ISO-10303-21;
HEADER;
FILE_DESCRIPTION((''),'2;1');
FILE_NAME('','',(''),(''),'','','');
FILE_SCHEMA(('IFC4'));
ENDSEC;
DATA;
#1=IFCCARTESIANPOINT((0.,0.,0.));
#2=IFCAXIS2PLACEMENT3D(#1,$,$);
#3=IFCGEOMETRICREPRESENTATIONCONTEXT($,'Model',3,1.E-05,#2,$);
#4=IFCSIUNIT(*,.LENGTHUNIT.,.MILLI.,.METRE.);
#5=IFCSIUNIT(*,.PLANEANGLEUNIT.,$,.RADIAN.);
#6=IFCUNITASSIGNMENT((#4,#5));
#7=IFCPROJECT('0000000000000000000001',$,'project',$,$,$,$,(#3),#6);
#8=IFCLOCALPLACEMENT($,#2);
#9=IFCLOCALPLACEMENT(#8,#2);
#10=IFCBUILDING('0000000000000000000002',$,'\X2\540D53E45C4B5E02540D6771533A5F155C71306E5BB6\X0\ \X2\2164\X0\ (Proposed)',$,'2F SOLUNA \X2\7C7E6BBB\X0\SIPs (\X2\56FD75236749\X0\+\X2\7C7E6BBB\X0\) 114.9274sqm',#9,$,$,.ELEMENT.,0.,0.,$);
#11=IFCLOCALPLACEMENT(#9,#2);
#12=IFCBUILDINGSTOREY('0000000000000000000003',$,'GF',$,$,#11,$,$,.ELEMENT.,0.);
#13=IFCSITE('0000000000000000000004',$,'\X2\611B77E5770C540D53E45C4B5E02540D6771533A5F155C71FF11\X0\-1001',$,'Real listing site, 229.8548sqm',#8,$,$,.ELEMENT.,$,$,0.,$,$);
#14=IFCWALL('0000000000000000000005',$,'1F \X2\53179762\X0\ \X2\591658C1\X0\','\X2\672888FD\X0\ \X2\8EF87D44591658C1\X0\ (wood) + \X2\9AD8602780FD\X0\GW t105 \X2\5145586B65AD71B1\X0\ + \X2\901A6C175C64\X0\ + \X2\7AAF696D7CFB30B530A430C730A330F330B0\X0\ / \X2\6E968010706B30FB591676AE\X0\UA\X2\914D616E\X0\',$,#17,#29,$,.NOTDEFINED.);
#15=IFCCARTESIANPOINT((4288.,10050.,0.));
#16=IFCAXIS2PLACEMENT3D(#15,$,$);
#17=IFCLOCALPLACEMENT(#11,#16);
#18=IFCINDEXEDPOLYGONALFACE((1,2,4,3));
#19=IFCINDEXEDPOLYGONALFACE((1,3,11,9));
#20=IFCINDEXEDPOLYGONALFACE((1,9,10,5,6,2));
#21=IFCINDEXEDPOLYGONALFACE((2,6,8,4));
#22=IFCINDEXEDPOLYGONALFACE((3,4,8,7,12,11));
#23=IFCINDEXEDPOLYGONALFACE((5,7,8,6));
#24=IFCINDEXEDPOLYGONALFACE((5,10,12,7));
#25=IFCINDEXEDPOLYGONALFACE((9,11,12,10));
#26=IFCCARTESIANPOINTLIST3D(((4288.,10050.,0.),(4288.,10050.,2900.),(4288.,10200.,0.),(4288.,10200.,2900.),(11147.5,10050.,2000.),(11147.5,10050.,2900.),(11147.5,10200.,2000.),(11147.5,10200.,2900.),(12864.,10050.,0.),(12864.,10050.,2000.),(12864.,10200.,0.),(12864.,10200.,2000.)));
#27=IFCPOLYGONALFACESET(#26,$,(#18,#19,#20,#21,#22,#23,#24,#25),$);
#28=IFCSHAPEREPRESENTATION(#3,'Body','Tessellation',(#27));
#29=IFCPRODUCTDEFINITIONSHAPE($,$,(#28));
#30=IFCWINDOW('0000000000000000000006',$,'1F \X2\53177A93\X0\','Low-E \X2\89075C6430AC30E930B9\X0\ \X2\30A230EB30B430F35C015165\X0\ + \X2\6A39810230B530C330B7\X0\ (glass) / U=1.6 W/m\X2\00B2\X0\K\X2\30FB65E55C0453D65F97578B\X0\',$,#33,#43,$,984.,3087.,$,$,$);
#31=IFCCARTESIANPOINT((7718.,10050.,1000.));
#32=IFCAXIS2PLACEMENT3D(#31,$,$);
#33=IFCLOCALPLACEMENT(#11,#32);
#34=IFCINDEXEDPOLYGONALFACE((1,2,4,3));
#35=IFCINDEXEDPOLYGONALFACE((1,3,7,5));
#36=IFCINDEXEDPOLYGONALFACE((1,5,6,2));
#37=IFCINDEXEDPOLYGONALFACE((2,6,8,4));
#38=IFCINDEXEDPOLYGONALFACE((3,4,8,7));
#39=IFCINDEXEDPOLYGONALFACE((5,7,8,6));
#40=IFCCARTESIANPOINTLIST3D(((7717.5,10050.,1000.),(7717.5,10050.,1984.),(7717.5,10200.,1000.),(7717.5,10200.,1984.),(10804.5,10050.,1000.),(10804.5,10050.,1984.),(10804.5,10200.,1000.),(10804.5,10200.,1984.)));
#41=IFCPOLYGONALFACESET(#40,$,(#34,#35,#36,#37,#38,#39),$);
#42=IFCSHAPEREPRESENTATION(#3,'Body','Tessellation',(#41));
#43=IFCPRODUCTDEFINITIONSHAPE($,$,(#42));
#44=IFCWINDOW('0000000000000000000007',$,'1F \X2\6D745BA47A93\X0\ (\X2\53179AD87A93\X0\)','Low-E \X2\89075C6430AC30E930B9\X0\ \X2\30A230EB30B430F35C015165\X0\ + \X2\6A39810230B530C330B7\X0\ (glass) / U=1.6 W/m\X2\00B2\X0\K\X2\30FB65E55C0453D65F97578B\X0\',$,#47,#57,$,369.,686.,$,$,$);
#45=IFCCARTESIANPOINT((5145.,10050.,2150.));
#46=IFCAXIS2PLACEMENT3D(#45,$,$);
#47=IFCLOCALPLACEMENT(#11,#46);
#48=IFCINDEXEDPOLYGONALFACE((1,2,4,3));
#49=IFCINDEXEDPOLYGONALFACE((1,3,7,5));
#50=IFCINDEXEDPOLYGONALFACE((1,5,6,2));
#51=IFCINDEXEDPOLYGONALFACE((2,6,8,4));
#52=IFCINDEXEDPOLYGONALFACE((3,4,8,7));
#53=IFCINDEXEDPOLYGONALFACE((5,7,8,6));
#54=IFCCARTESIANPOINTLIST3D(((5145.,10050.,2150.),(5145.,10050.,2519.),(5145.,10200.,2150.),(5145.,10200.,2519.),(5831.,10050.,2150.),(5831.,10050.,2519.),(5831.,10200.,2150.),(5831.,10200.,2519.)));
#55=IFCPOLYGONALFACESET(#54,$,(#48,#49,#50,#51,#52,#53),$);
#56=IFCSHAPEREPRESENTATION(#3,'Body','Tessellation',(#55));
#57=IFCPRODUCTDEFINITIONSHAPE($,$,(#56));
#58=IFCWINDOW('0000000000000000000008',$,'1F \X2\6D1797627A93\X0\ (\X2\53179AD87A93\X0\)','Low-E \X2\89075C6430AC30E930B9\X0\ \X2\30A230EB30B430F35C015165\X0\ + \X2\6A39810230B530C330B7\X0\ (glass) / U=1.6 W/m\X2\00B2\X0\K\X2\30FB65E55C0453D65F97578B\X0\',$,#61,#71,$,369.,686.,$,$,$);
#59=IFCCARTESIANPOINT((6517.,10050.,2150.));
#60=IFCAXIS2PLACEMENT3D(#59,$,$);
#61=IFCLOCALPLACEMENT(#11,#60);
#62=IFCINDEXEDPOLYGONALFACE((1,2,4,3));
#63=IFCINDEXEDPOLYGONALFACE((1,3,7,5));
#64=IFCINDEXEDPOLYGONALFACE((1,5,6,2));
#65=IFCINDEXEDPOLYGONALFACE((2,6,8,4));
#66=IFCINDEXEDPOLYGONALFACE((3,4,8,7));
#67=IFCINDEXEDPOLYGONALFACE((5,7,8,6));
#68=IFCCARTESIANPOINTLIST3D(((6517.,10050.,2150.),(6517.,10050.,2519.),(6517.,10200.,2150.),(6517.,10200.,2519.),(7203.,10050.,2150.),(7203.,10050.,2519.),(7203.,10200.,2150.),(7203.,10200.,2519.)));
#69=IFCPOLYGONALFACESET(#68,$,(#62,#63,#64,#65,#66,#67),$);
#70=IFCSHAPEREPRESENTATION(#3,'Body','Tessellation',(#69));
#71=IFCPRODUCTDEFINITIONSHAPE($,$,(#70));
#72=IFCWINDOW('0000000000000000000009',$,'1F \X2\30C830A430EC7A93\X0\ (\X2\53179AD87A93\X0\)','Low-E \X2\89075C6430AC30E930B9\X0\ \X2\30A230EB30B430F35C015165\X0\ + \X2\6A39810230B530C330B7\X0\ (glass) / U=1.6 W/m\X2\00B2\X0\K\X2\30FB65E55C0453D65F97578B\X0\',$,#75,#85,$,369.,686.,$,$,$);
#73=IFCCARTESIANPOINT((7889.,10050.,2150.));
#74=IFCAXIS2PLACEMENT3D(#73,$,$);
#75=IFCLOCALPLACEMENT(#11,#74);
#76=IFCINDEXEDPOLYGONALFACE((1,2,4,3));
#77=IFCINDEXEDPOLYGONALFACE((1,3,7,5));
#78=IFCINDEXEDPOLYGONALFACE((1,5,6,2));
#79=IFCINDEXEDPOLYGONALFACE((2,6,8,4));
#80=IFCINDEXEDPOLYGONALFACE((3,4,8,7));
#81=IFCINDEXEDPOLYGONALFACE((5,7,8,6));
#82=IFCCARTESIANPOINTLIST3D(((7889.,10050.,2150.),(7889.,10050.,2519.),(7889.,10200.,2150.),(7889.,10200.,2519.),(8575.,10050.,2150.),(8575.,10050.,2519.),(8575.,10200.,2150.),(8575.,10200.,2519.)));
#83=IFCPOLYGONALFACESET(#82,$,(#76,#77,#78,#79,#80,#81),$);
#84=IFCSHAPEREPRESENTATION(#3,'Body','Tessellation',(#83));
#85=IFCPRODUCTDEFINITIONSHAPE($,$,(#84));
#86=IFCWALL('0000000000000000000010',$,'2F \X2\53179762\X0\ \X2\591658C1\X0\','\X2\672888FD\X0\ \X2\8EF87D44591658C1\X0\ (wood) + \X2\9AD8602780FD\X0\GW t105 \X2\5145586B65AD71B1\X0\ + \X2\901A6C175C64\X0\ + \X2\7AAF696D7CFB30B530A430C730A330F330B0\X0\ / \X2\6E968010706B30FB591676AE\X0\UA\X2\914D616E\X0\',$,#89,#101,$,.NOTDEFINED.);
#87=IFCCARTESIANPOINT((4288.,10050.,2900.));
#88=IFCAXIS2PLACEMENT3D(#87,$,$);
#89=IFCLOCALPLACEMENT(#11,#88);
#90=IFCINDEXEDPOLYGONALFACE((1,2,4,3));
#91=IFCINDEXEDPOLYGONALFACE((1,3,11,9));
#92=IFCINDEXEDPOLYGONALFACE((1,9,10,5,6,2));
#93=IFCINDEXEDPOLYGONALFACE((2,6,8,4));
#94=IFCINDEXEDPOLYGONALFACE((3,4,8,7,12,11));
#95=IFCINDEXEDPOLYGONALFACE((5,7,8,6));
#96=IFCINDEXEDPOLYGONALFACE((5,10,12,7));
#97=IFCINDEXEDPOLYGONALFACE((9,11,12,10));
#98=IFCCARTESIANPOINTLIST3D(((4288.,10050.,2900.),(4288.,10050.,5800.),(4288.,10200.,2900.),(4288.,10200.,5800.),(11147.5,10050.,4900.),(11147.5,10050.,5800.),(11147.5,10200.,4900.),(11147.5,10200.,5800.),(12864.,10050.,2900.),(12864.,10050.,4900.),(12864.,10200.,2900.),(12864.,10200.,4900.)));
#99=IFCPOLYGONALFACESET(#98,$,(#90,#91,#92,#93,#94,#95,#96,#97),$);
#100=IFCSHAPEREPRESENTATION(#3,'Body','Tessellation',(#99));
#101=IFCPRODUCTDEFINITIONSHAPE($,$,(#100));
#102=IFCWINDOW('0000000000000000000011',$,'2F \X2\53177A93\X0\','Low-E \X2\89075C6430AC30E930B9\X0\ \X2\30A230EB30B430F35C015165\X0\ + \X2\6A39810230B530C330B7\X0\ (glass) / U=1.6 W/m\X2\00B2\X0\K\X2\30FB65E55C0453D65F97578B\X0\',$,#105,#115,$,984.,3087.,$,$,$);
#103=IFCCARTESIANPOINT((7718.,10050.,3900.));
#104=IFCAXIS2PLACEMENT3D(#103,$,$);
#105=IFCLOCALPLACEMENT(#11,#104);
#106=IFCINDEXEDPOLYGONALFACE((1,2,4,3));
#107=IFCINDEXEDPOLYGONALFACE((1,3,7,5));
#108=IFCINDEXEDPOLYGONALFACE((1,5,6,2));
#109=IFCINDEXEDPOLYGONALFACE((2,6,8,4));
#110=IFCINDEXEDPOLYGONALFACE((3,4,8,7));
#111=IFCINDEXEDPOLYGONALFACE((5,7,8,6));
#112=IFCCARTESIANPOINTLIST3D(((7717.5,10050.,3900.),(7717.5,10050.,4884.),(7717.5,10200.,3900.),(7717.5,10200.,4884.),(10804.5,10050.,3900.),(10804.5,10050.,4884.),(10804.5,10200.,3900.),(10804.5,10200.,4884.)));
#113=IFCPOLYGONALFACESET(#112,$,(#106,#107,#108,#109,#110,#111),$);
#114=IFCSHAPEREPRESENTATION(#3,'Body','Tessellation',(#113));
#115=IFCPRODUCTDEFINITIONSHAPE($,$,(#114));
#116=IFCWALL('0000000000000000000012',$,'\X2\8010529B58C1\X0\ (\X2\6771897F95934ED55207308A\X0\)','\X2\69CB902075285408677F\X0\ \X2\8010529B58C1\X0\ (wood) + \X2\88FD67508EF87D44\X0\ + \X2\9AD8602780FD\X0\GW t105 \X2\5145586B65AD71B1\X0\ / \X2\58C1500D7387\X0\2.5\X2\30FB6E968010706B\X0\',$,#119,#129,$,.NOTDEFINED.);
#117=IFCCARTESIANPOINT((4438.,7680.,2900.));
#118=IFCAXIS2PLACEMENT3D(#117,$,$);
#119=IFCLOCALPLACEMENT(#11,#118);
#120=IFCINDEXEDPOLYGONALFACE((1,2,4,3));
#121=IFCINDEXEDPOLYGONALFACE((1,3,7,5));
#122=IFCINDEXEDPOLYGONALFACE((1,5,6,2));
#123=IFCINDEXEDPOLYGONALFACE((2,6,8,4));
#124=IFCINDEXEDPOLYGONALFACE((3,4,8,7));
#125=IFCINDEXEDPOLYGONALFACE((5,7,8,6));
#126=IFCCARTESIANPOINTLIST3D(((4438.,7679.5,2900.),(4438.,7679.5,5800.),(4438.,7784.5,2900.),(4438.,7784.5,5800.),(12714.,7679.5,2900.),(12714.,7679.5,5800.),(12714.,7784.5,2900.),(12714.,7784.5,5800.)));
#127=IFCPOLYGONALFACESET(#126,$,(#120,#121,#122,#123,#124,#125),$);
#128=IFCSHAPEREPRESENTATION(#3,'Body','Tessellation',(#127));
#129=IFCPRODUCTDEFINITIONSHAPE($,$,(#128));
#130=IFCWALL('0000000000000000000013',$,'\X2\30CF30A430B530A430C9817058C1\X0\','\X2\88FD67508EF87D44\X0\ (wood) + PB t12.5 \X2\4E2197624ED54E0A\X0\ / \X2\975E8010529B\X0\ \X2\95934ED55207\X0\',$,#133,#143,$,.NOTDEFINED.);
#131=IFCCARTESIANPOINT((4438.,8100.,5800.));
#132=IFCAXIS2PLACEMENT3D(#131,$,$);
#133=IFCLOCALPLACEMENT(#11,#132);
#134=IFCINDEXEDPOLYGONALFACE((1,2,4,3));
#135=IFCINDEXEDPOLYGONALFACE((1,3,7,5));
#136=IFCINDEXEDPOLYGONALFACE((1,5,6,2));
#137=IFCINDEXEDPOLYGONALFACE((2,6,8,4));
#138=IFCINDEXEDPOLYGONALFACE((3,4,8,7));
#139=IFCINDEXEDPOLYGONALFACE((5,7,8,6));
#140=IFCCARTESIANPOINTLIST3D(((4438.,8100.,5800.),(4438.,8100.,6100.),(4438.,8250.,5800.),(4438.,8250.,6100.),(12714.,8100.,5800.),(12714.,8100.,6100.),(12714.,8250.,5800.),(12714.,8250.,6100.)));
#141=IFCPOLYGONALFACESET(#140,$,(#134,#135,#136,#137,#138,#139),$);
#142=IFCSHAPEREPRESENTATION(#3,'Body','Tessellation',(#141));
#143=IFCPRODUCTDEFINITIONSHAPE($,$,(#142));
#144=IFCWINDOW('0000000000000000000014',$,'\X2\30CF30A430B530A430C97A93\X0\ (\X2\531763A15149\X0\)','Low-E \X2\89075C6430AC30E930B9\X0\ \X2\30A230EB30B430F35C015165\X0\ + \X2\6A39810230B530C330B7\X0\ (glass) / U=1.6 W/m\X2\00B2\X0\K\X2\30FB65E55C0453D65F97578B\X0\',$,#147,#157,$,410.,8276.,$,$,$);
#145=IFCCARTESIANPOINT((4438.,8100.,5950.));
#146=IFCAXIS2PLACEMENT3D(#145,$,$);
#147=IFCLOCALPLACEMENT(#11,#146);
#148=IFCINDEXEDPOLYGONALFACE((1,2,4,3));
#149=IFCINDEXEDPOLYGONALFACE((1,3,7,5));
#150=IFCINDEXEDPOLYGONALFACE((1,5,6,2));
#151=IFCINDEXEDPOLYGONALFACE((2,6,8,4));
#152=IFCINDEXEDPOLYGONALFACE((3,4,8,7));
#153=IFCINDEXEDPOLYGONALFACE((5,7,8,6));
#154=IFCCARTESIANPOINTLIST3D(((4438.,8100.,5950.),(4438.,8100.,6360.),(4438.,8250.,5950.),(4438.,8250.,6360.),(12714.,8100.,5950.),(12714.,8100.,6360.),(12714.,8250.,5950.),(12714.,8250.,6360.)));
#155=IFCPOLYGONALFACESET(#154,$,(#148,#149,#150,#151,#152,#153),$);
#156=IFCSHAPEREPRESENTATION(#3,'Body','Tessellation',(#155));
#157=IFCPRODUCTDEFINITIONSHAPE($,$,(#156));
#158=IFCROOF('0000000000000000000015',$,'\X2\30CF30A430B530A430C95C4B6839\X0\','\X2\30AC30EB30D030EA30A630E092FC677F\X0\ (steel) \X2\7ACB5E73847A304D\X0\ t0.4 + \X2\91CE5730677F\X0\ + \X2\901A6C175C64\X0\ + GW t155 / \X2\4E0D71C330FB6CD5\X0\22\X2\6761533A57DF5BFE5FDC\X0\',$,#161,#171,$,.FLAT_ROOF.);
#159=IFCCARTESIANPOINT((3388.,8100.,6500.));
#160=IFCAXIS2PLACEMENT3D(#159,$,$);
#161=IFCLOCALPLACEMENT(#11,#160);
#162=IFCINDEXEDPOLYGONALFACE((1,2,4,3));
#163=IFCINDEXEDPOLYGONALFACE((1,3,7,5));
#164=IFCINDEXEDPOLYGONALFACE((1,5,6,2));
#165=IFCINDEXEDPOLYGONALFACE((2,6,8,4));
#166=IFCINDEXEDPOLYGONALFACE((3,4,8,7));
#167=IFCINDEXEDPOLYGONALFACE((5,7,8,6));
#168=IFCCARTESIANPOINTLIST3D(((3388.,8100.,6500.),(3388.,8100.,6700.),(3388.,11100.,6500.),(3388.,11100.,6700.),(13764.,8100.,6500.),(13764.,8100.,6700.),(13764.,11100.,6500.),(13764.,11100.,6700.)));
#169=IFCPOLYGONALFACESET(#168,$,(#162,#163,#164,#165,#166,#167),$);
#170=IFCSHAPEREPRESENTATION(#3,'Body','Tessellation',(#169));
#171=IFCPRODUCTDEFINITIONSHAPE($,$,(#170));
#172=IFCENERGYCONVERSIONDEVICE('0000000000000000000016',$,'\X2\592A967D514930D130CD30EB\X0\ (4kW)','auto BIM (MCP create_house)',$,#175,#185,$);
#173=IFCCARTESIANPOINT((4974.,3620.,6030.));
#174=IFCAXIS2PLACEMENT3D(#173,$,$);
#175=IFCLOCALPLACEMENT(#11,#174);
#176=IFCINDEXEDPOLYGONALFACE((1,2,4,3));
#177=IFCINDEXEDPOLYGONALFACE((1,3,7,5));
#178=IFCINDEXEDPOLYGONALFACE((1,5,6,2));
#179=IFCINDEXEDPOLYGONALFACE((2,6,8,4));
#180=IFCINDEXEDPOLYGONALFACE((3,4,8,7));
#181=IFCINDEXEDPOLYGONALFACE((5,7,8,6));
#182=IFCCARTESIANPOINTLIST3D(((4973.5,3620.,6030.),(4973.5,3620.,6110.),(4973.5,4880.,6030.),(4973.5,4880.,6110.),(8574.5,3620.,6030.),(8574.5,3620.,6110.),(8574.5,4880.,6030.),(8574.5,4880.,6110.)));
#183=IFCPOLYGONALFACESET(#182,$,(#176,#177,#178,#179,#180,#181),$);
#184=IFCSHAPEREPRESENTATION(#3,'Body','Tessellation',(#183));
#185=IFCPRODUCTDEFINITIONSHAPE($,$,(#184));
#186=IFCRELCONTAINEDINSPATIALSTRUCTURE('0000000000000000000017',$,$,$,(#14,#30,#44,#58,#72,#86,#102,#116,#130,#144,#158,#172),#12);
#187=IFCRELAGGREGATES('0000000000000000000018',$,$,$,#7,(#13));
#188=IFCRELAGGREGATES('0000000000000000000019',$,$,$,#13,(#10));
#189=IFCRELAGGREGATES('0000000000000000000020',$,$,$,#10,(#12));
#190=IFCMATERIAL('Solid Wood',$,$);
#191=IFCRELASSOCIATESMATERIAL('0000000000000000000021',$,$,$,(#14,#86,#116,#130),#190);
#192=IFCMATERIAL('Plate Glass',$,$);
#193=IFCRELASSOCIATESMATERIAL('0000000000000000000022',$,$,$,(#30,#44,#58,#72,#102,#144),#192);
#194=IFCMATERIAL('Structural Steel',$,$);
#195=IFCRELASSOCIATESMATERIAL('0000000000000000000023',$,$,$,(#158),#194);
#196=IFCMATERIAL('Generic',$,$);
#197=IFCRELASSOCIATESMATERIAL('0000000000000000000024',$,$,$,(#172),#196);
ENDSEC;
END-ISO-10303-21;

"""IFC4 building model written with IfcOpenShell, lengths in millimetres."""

from ifc_helpers import new_model, si_unit, frame, frame_2d, origin, place, context, project, spatial, rectangle, extrude, material, element, fill, save


model = new_model("IFC4")

# Units and contexts
model_context = context("Model", 3, precision=1e-05, world=origin())
ifc_project = project(units=[si_unit("LENGTHUNIT", "METRE", prefix="MILLI"), si_unit("PLANEANGLEUNIT", "RADIAN")], contexts=[model_context])

# Site, building, storey
site_placement = place(None, origin())
site = spatial("IfcSite", under=ifc_project, at=site_placement, Name="愛知県名古屋市名東区引山１-1001", ObjectType="Real listing site, 229.8548sqm", CompositionType="ELEMENT", RefElevation=0.0)
building_placement = place(site_placement, origin())
building = spatial("IfcBuilding", under=site, at=building_placement, Name="名古屋市名東区引山の家 Ⅴ (Proposed)", ObjectType="2F SOLUNA 籾殻SIPs (国産杉+籾殻) 114.9274sqm", CompositionType="ELEMENT", ElevationOfRefHeight=0.0, ElevationOfTerrain=0.0)
storey_placement = place(building_placement, origin())
storey = spatial("IfcBuildingStorey", under=building, at=storey_placement, Name="GF", CompositionType="ELEMENT", Elevation=0.0)

# Wall, openings, windows
ifc_material_1 = material(Name="Solid Wood")
wall_1_placement = place(storey_placement, frame((4288.0, 10050.0, 0.0)))
wall_1 = element("IfcWall", 1, at=wall_1_placement, inside=storey, material=ifc_material_1, Name="1F 北面 外壁", Description="木製 軸組外壁 (wood) + 高性能GW t105 充填断熱 + 通気層 + 窯業系サイディング / 準耐火・外皮UA配慮", PredefinedType="NOTDEFINED", context=model_context, shape_type="SweptSolid", body=[
    extrude(rectangle(XDim=8576.0, YDim=150.0, at=frame_2d((4288.0, 75.0))), frame((4288.0, 10050.0, 0.0)), (0.0, 0.0, 1.0), 2900.0),
])
opening_1_placement = place(storey_placement, frame((7718.0, 10050.0, 1000.0)))
opening_1 = element("IfcOpeningElement", 2, at=opening_1_placement, cuts=wall_1, PredefinedType="NOTDEFINED", context=model_context, shape_type="SweptSolid", body=[
    extrude(rectangle(XDim=3087.0, YDim=150.0, at=frame_2d((1543.0, 75.0))), frame((7718.0, 10050.0, 1000.0)), (0.0, 0.0, 1.0), 984.0),
])
opening_2_placement = place(storey_placement, frame((5145.0, 10050.0, 2150.0)))
opening_2 = element("IfcOpeningElement", 3, at=opening_2_placement, cuts=wall_1, PredefinedType="NOTDEFINED", context=model_context, shape_type="SweptSolid", body=[
    extrude(rectangle(XDim=686.0, YDim=150.0, at=frame_2d((343.0, 75.0))), frame((5145.0, 10050.0, 2150.0)), (0.0, 0.0, 1.0), 369.0),
])
opening_3_placement = place(storey_placement, frame((6517.0, 10050.0, 2150.0)))
opening_3 = element("IfcOpeningElement", 4, at=opening_3_placement, cuts=wall_1, PredefinedType="NOTDEFINED", context=model_context, shape_type="SweptSolid", body=[
    extrude(rectangle(XDim=686.0, YDim=150.0, at=frame_2d((343.0, 75.0))), frame((6517.0, 10050.0, 2150.0)), (0.0, 0.0, 1.0), 369.0),
])
opening_4_placement = place(storey_placement, frame((7889.0, 10050.0, 2150.0)))
opening_4 = element("IfcOpeningElement", 5, at=opening_4_placement, cuts=wall_1, PredefinedType="NOTDEFINED", context=model_context, shape_type="SweptSolid", body=[
    extrude(rectangle(XDim=686.0, YDim=150.0, at=frame_2d((343.0, 75.0))), frame((7889.0, 10050.0, 2150.0)), (0.0, 0.0, 1.0), 369.0),
])
ifc_material_2 = material(Name="Plate Glass")
window_1_placement = place(storey_placement, frame((7718.0, 10050.0, 1000.0)))
window_1 = element("IfcWindow", 6, at=window_1_placement, inside=storey, material=ifc_material_2, Name="1F 北窓", Description="Low-E 複層ガラス アルゴン封入 + 樹脂サッシ (glass) / U=1.6 W/m²K・日射取得型", OverallHeight=984.0, OverallWidth=3087.0, context=model_context, shape_type="SweptSolid", body=[
    extrude(rectangle(XDim=3087.0, YDim=150.0, at=frame_2d((1543.0, 75.0))), frame((7718.0, 10050.0, 1000.0)), (0.0, 0.0, 1.0), 984.0),
])
fill(opening_1, window_1)
window_2_placement = place(storey_placement, frame((5145.0, 10050.0, 2150.0)))
window_2 = element("IfcWindow", 7, at=window_2_placement, inside=storey, material=ifc_material_2, Name="1F 浴室窓 (北高窓)", Description="Low-E 複層ガラス アルゴン封入 + 樹脂サッシ (glass) / U=1.6 W/m²K・日射取得型", OverallHeight=369.0, OverallWidth=686.0, context=model_context, shape_type="SweptSolid", body=[
    extrude(rectangle(XDim=686.0, YDim=150.0, at=frame_2d((343.0, 75.0))), frame((5145.0, 10050.0, 2150.0)), (0.0, 0.0, 1.0), 369.0),
])
fill(opening_2, window_2)
window_3_placement = place(storey_placement, frame((6517.0, 10050.0, 2150.0)))
window_3 = element("IfcWindow", 8, at=window_3_placement, inside=storey, material=ifc_material_2, Name="1F 洗面窓 (北高窓)", Description="Low-E 複層ガラス アルゴン封入 + 樹脂サッシ (glass) / U=1.6 W/m²K・日射取得型", OverallHeight=369.0, OverallWidth=686.0, context=model_context, shape_type="SweptSolid", body=[
    extrude(rectangle(XDim=686.0, YDim=150.0, at=frame_2d((343.0, 75.0))), frame((6517.0, 10050.0, 2150.0)), (0.0, 0.0, 1.0), 369.0),
])
fill(opening_3, window_3)
window_4_placement = place(storey_placement, frame((7889.0, 10050.0, 2150.0)))
window_4 = element("IfcWindow", 9, at=window_4_placement, inside=storey, material=ifc_material_2, Name="1F トイレ窓 (北高窓)", Description="Low-E 複層ガラス アルゴン封入 + 樹脂サッシ (glass) / U=1.6 W/m²K・日射取得型", OverallHeight=369.0, OverallWidth=686.0, context=model_context, shape_type="SweptSolid", body=[
    extrude(rectangle(XDim=686.0, YDim=150.0, at=frame_2d((343.0, 75.0))), frame((7889.0, 10050.0, 2150.0)), (0.0, 0.0, 1.0), 369.0),
])
fill(opening_4, window_4)

# Wall, opening, window
wall_2_placement = place(storey_placement, frame((4288.0, 10050.0, 2900.0)))
wall_2 = element("IfcWall", 10, at=wall_2_placement, inside=storey, material=ifc_material_1, Name="2F 北面 外壁", Description="木製 軸組外壁 (wood) + 高性能GW t105 充填断熱 + 通気層 + 窯業系サイディング / 準耐火・外皮UA配慮", PredefinedType="NOTDEFINED", context=model_context, shape_type="SweptSolid", body=[
    extrude(rectangle(XDim=8576.0, YDim=150.0, at=frame_2d((4288.0, 75.0))), frame((4288.0, 10050.0, 2900.0)), (0.0, 0.0, 1.0), 2900.0),
])
opening_5_placement = place(storey_placement, frame((7718.0, 10050.0, 3900.0)))
opening_5 = element("IfcOpeningElement", 11, at=opening_5_placement, cuts=wall_2, PredefinedType="NOTDEFINED", context=model_context, shape_type="SweptSolid", body=[
    extrude(rectangle(XDim=3087.0, YDim=150.0, at=frame_2d((1543.0, 75.0))), frame((7718.0, 10050.0, 3900.0)), (0.0, 0.0, 1.0), 984.0),
])
window_5_placement = place(storey_placement, frame((7718.0, 10050.0, 3900.0)))
window_5 = element("IfcWindow", 12, at=window_5_placement, inside=storey, material=ifc_material_2, Name="2F 北窓", Description="Low-E 複層ガラス アルゴン封入 + 樹脂サッシ (glass) / U=1.6 W/m²K・日射取得型", OverallHeight=984.0, OverallWidth=3087.0, context=model_context, shape_type="SweptSolid", body=[
    extrude(rectangle(XDim=3087.0, YDim=150.0, at=frame_2d((1543.0, 75.0))), frame((7718.0, 10050.0, 3900.0)), (0.0, 0.0, 1.0), 984.0),
])
fill(opening_5, window_5)

# Wall
wall_3_placement = place(storey_placement, frame((4438.0, 7680.0, 2900.0)))
element("IfcWall", 13, at=wall_3_placement, inside=storey, material=ifc_material_1, Name="耐力壁 (東西間仕切り)", Description="構造用合板 耐力壁 (wood) + 製材軸組 + 高性能GW t105 充填断熱 / 壁倍率2.5・準耐火", PredefinedType="NOTDEFINED", context=model_context, shape_type="SweptSolid", body=[
    extrude(rectangle(XDim=8276.0, YDim=105.0, at=frame_2d((4138.0, 52.0))), frame((4438.0, 7680.0, 2900.0)), (0.0, 0.0, 1.0), 2900.0),
])

# Wall, opening, window
wall_4_placement = place(storey_placement, frame((4438.0, 8100.0, 5800.0)))
wall_4 = element("IfcWall", 14, at=wall_4_placement, inside=storey, material=ifc_material_1, Name="ハイサイド腰壁", Description="製材軸組 (wood) + PB t12.5 両面仕上 / 非耐力 間仕切", PredefinedType="NOTDEFINED", context=model_context, shape_type="SweptSolid", body=[
    extrude(rectangle(XDim=8276.0, YDim=150.0, at=frame_2d((4138.0, 75.0))), frame((4438.0, 8100.0, 5800.0)), (0.0, 0.0, 1.0), 700.0),
])
opening_6_placement = place(storey_placement, frame((4438.0, 8100.0, 5950.0)))
opening_6 = element("IfcOpeningElement", 15, at=opening_6_placement, cuts=wall_4, PredefinedType="NOTDEFINED", context=model_context, shape_type="SweptSolid", body=[
    extrude(rectangle(XDim=8276.0, YDim=150.0, at=frame_2d((4138.0, 75.0))), frame((4438.0, 8100.0, 5950.0)), (0.0, 0.0, 1.0), 410.0),
])
window_6_placement = place(storey_placement, frame((4438.0, 8100.0, 5950.0)))
window_6 = element("IfcWindow", 16, at=window_6_placement, inside=storey, material=ifc_material_2, Name="ハイサイド窓 (北採光)", Description="Low-E 複層ガラス アルゴン封入 + 樹脂サッシ (glass) / U=1.6 W/m²K・日射取得型", OverallHeight=410.0, OverallWidth=8276.0, context=model_context, shape_type="SweptSolid", body=[
    extrude(rectangle(XDim=8276.0, YDim=150.0, at=frame_2d((4138.0, 75.0))), frame((4438.0, 8100.0, 5950.0)), (0.0, 0.0, 1.0), 410.0),
])
fill(opening_6, window_6)

# Roof
ifc_material_3 = material(Name="Structural Steel")
roof_placement = place(storey_placement, frame((3388.0, 8100.0, 6500.0)))
element("IfcRoof", 17, at=roof_placement, inside=storey, material=ifc_material_3, Name="ハイサイド屋根", Description="ガルバリウム鋼板 (steel) 立平葺き t0.4 + 野地板 + 通気層 + GW t155 / 不燃・法22条区域対応", PredefinedType="FLAT_ROOF", context=model_context, shape_type="SweptSolid", body=[
    extrude(rectangle(XDim=10376.0, YDim=3000.0, at=frame_2d((5188.0, 1500.0))), frame((3388.0, 8100.0, 6500.0)), (0.0, 0.0, 1.0), 200.0),
])

# Energy conversion device
ifc_material_4 = material(Name="Generic")
energy_conversion_device_placement = place(storey_placement, frame((4974.0, 3620.0, 6030.0)))
element("IfcEnergyConversionDevice", 18, at=energy_conversion_device_placement, inside=storey, material=ifc_material_4, Name="太陽光パネル (4kW)", Description="auto BIM (MCP create_house)", context=model_context, shape_type="SweptSolid", body=[
    extrude(rectangle(XDim=3601.0, YDim=1260.0, at=frame_2d((1800.0, 630.0))), frame((4974.0, 3620.0, 6030.0)), (0.0, 0.0, 1.0), 80.0),
])

save(model, "model.ifc")
